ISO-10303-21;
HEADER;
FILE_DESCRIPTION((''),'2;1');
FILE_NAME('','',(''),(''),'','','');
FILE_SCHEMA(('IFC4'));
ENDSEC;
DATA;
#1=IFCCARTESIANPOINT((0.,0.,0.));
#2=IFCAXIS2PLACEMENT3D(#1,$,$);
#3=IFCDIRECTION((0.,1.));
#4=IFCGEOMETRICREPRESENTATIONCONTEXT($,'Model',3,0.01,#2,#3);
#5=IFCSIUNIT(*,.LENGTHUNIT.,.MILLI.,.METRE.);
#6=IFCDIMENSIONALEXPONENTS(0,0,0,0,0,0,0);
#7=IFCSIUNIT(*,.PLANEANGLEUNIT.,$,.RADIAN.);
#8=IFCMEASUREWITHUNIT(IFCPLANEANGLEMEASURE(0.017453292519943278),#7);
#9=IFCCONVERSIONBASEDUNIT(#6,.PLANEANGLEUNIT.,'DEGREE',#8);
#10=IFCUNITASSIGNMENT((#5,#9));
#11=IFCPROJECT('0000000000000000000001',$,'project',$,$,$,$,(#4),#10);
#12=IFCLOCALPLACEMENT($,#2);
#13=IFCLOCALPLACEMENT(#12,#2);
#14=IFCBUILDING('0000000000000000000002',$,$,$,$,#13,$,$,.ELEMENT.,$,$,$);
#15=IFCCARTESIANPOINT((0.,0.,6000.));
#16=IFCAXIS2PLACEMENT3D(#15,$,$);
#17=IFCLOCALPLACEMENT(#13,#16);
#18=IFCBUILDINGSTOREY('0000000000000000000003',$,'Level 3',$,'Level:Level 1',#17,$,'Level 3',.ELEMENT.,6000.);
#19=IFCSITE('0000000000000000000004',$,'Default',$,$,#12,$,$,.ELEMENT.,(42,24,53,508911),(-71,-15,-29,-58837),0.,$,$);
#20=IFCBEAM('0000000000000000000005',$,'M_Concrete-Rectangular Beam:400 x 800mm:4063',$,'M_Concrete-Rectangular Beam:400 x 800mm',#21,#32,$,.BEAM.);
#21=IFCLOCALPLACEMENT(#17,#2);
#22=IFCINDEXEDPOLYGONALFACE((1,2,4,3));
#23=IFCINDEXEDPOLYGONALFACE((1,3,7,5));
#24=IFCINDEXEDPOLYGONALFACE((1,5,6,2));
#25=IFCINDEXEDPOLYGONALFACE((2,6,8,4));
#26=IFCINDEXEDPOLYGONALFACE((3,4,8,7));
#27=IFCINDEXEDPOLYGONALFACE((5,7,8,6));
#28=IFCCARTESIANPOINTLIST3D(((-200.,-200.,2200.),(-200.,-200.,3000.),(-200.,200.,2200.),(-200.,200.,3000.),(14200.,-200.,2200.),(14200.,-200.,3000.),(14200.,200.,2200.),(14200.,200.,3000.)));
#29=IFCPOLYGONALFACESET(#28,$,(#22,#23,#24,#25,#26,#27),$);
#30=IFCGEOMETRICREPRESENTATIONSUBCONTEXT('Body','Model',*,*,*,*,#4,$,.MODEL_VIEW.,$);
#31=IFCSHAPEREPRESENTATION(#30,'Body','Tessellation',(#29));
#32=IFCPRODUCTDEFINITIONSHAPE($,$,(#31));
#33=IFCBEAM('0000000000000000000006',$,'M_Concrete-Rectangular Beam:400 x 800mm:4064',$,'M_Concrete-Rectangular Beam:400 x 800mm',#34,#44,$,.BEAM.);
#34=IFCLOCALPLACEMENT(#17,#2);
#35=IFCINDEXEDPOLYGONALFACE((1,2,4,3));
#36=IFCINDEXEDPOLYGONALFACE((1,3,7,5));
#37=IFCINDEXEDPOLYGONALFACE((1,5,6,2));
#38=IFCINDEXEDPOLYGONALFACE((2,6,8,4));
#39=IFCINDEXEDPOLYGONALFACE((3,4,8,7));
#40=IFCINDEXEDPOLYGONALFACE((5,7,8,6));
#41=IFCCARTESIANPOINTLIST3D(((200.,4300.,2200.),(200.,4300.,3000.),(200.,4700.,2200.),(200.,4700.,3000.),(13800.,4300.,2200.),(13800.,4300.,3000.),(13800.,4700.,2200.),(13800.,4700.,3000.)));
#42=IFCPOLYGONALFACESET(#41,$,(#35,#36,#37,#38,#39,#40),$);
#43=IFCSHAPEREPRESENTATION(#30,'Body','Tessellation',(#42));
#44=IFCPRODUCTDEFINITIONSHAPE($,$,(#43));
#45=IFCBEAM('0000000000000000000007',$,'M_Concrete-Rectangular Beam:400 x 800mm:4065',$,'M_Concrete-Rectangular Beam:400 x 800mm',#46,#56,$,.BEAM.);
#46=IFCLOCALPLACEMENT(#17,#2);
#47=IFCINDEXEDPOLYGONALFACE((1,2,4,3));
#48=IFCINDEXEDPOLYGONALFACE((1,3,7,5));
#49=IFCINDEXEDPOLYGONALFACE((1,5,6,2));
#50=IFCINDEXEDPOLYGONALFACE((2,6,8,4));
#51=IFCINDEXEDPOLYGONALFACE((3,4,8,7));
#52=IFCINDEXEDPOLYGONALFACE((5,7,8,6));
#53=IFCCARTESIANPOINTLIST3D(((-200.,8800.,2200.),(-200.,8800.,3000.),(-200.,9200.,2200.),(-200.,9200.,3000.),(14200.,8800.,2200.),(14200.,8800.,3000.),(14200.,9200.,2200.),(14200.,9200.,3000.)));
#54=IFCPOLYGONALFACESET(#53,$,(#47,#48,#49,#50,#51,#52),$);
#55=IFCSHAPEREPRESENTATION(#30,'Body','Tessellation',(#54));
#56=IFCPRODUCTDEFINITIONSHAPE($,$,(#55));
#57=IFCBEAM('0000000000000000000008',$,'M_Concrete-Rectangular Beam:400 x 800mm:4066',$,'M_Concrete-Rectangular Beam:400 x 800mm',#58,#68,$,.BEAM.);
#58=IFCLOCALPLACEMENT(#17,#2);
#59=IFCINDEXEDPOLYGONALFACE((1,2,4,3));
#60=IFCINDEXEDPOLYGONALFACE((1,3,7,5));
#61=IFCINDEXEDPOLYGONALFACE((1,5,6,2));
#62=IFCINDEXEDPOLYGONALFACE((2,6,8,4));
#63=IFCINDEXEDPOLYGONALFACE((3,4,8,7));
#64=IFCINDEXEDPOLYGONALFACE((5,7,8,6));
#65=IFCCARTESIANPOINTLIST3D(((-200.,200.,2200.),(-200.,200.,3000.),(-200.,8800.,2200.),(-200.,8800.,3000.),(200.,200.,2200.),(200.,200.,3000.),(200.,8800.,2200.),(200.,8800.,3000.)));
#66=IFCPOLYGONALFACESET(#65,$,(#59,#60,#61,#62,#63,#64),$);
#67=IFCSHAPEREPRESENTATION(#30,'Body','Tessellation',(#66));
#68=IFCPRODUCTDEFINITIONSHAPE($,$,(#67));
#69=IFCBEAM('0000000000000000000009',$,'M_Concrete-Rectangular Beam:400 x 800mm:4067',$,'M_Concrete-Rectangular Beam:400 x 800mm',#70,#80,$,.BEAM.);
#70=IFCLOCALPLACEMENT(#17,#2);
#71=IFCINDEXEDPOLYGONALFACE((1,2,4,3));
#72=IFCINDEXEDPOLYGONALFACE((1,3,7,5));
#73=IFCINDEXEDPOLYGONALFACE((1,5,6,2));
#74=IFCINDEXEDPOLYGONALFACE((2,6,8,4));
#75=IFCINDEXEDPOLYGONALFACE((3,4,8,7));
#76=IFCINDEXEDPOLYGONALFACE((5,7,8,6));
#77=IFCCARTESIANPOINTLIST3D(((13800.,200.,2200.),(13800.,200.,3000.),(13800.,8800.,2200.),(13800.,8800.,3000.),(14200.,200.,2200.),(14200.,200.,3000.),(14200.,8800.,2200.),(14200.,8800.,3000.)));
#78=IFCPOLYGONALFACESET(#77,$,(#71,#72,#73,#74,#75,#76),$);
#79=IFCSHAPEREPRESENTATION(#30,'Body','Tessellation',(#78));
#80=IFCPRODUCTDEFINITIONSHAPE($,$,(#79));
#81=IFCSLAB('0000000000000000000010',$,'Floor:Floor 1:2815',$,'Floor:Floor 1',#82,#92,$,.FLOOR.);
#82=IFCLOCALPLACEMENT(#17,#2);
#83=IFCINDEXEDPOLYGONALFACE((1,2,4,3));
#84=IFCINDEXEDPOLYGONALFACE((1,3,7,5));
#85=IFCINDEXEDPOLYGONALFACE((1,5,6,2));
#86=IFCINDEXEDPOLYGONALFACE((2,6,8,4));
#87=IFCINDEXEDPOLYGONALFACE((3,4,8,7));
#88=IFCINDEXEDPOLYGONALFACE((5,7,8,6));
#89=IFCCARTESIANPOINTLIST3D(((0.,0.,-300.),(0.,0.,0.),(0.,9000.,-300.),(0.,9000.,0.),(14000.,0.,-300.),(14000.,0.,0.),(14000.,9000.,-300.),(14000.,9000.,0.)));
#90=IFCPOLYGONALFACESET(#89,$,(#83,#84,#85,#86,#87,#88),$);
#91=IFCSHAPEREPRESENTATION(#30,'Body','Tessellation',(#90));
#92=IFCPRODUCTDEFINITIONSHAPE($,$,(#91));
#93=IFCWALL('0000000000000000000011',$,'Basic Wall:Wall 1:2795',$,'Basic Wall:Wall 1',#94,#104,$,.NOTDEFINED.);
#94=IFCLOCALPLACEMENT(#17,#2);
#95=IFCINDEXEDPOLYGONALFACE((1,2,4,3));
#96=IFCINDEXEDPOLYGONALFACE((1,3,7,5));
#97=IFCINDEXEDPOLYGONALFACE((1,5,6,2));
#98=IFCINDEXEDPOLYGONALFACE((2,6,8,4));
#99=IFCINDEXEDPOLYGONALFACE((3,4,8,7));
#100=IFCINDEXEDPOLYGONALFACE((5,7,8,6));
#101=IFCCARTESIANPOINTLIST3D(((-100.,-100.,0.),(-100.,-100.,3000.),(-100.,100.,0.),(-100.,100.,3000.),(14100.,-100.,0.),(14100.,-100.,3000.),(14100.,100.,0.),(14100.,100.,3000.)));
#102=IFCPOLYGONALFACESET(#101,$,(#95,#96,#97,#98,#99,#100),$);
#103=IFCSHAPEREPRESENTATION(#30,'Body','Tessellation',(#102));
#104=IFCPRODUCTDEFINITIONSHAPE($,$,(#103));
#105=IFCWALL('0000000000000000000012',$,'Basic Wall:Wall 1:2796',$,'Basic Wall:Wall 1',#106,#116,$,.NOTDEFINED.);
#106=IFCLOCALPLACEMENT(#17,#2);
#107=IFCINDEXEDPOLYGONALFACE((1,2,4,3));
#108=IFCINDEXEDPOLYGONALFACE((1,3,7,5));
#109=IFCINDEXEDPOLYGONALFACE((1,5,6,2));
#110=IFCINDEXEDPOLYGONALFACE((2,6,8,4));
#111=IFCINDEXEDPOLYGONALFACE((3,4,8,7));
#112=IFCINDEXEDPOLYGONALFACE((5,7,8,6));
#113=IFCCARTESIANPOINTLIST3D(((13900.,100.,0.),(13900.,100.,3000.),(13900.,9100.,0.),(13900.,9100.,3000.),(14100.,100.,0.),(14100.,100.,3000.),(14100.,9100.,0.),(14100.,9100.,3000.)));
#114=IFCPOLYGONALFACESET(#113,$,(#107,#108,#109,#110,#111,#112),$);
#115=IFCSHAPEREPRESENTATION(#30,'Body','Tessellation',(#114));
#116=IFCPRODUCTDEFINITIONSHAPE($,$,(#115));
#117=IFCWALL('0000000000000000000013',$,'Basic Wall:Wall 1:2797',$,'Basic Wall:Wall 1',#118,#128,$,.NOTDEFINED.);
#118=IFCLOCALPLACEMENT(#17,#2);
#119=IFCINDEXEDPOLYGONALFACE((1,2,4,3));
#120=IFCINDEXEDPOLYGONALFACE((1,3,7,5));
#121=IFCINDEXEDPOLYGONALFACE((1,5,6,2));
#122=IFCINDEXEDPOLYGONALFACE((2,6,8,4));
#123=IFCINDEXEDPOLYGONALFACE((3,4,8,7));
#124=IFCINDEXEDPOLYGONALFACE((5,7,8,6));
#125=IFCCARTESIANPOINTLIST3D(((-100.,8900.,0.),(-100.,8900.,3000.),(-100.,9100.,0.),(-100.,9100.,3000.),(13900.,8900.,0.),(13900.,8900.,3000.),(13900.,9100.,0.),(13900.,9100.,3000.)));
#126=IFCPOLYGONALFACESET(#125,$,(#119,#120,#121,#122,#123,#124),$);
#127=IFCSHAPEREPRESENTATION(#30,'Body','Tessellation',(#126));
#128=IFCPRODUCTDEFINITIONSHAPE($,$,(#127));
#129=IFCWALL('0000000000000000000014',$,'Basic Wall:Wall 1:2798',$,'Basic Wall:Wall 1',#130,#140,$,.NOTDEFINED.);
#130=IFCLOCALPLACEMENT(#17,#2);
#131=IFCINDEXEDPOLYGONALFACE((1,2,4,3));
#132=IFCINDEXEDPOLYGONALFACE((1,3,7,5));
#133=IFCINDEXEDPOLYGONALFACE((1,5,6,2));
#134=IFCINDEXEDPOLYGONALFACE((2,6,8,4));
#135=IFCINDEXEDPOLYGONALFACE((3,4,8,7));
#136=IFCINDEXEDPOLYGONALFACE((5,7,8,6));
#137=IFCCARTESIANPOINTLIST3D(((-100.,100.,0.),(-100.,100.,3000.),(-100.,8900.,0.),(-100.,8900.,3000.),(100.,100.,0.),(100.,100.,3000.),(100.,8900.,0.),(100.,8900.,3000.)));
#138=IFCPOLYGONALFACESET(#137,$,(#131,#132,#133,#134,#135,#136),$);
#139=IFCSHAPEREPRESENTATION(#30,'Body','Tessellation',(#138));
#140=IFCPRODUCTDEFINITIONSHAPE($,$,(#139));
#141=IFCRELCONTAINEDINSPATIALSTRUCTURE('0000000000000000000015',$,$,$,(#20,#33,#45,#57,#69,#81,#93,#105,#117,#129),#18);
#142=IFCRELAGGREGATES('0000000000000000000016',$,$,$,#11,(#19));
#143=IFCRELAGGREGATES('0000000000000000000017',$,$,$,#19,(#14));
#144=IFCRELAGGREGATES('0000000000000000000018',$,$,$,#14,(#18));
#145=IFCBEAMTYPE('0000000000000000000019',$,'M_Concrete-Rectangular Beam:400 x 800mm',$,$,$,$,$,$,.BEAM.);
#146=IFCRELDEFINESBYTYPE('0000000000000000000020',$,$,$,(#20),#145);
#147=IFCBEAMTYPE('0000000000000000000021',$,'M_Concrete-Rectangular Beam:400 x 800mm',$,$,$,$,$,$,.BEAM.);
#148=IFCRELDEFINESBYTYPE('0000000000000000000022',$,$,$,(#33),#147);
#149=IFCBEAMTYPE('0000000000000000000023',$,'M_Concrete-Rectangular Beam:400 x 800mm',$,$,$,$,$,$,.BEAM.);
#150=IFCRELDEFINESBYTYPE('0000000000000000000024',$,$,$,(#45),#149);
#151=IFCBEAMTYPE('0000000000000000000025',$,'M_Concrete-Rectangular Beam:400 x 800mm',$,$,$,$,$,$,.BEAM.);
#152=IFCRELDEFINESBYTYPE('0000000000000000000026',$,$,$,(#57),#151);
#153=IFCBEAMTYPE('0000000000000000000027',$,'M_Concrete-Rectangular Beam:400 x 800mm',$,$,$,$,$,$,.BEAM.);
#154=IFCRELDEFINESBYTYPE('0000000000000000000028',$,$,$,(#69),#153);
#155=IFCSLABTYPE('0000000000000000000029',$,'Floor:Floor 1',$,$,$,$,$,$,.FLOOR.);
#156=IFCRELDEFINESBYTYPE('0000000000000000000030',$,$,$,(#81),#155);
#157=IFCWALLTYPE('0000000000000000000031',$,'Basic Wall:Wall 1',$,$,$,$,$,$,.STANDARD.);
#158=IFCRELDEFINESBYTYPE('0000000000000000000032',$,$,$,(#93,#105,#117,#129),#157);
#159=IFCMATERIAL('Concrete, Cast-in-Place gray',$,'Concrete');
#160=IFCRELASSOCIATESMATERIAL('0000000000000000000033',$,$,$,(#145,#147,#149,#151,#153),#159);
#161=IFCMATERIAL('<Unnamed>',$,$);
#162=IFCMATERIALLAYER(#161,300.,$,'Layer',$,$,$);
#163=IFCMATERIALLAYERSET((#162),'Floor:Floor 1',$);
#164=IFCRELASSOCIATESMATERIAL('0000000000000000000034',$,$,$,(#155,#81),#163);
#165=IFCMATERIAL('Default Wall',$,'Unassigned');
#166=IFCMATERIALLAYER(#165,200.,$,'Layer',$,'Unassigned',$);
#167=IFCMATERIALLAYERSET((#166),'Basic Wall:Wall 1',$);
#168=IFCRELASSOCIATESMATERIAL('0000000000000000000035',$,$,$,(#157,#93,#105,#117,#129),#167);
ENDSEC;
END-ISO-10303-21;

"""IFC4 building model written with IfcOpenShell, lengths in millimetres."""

from ifc_helpers import new_model, entity, si_unit, converted_unit, direction, frame, frame_2d, origin, origin_2d_with_axis, place, context, subcontext, project, spatial, rectangle, extrude, source, transform, mapped, material, layer, layer_set, layer_usage, material_profile, profile_set, type_object, type_shapes, element, save


model = new_model("IFC4")

# Units and contexts
model_context = context("Model", 3, precision=0.01, world=origin(), true_north=direction((0.0, 1.0)))
body_context = subcontext(model_context, "Body", "Model", "MODEL_VIEW")
ifc_project = project(units=[si_unit("LENGTHUNIT", "METRE", prefix="MILLI"), converted_unit("PLANEANGLEUNIT", "DEGREE", entity("IfcPlaneAngleMeasure", 0.017453292519943278), si_unit("PLANEANGLEUNIT", "RADIAN"), dimensions=[0, 0, 0, 0, 0, 0, 0])], contexts=[model_context])

# Site, building, storey
site_placement = place(None, origin())
site = spatial("IfcSite", under=ifc_project, at=site_placement, Name="Default", CompositionType="ELEMENT", RefLatitude=(42, 24, 53, 508911), RefLongitude=(-71, -15, -29, -58837), RefElevation=0.0)
building_placement = place(site_placement, origin())
building = spatial("IfcBuilding", under=site, at=building_placement, CompositionType="ELEMENT")
storey_placement = place(building_placement, frame((0.0, 0.0, 6000.0)))
storey = spatial("IfcBuildingStorey", under=building, at=storey_placement, Name="Level 3", ObjectType="Level:Level 1", LongName="Level 3", CompositionType="ELEMENT", Elevation=6000.0)

# Beams
ifc_material_1 = material(Name="Concrete, Cast-in-Place gray", Category="Concrete")
ifc_material_profile = material_profile(ifc_material_1, rectangle(XDim=800.0, YDim=400.0, at=origin_2d_with_axis()), Name="400 x 800mm")
ifc_profile_set = profile_set([ifc_material_profile], Name="400 x 800mm")
beam_type_1 = type_object("IfcBeamType", Name="M_Concrete-Rectangular Beam:400 x 800mm", PredefinedType="BEAM", material=ifc_profile_set)
shared_shape_1 = source(origin(), body_context, "Body", "SweptSolid", [
    extrude(rectangle(XDim=800.0, YDim=400.0, at=origin_2d_with_axis()), frame((-200.0, 0.0, 8600.0), z_axis=(1.0, 0.0, 0.0), x_axis=(0.0, 0.0, -1.0)), (0.0, 0.0, 1.0), 14400.0),
])
type_shapes(beam_type_1, [shared_shape_1])
beam_1_placement = place(storey_placement, frame((0.0, 0.0, -6000.0)))
element("IfcBeam", 1, at=beam_1_placement, inside=storey, type_object=beam_type_1, Name="M_Concrete-Rectangular Beam:400 x 800mm:4063", ObjectType="M_Concrete-Rectangular Beam:400 x 800mm", PredefinedType="BEAM", context=body_context, shape_type="MappedRepresentation", body=[
    mapped(shared_shape_1, transform((0.0, 0.0, 0.0), scale=1.0)),
])
beam_type_2 = type_object("IfcBeamType", Name="M_Concrete-Rectangular Beam:400 x 800mm", PredefinedType="BEAM", material=ifc_profile_set)
shared_shape_2 = source(origin(), body_context, "Body", "SweptSolid", [
    extrude(rectangle(XDim=800.0, YDim=400.0, at=origin_2d_with_axis()), frame((200.0, 4500.0, 8600.0), z_axis=(1.0, 0.0, 0.0), x_axis=(0.0, 0.0, -1.0)), (0.0, 0.0, 1.0), 13600.0),
])
type_shapes(beam_type_2, [shared_shape_2])
beam_2_placement = place(storey_placement, frame((0.0, 0.0, -6000.0)))
element("IfcBeam", 2, at=beam_2_placement, inside=storey, type_object=beam_type_2, Name="M_Concrete-Rectangular Beam:400 x 800mm:4064", ObjectType="M_Concrete-Rectangular Beam:400 x 800mm", PredefinedType="BEAM", context=body_context, shape_type="MappedRepresentation", body=[
    mapped(shared_shape_2, transform((0.0, 0.0, 0.0), scale=1.0)),
])
beam_type_3 = type_object("IfcBeamType", Name="M_Concrete-Rectangular Beam:400 x 800mm", PredefinedType="BEAM", material=ifc_profile_set)
shared_shape_3 = source(origin(), body_context, "Body", "SweptSolid", [
    extrude(rectangle(XDim=800.0, YDim=400.0, at=frame_2d((0.0, 0.0), x_axis=(1.0, 0.0))), frame((-200.0, 9000.0, 8600.0), z_axis=(1.0, 0.0, 0.0), x_axis=(0.0, 0.0, -1.0)), (0.0, 0.0, 1.0), 14400.0),
])
type_shapes(beam_type_3, [shared_shape_3])
beam_3_placement = place(storey_placement, frame((0.0, 0.0, -6000.0)))
element("IfcBeam", 3, at=beam_3_placement, inside=storey, type_object=beam_type_3, Name="M_Concrete-Rectangular Beam:400 x 800mm:4065", ObjectType="M_Concrete-Rectangular Beam:400 x 800mm", PredefinedType="BEAM", context=body_context, shape_type="MappedRepresentation", body=[
    mapped(shared_shape_3, transform((0.0, 0.0, 0.0), scale=1.0)),
])
beam_type_4 = type_object("IfcBeamType", Name="M_Concrete-Rectangular Beam:400 x 800mm", PredefinedType="BEAM", material=ifc_profile_set)
shared_shape_4 = source(origin(), body_context, "Body", "SweptSolid", [
    extrude(rectangle(XDim=800.0, YDim=400.0, at=frame_2d((0.0, 0.0), x_axis=(0.0, 1.0))), frame((0.0, 200.0, 8600.0), z_axis=(0.0, 1.0, 0.0), x_axis=(-1.0, 0.0, 0.0)), (0.0, 0.0, 1.0), 8600.0),
])
type_shapes(beam_type_4, [shared_shape_4])
beam_4_placement = place(storey_placement, frame((0.0, 0.0, -6000.0)))
element("IfcBeam", 4, at=beam_4_placement, inside=storey, type_object=beam_type_4, Name="M_Concrete-Rectangular Beam:400 x 800mm:4066", ObjectType="M_Concrete-Rectangular Beam:400 x 800mm", PredefinedType="BEAM", context=body_context, shape_type="MappedRepresentation", body=[
    mapped(shared_shape_4, transform((0.0, 0.0, 0.0), scale=1.0)),
])
beam_type_5 = type_object("IfcBeamType", Name="M_Concrete-Rectangular Beam:400 x 800mm", PredefinedType="BEAM", material=ifc_profile_set)
shared_shape_5 = source(origin(), body_context, "Body", "SweptSolid", [
    extrude(rectangle(XDim=800.0, YDim=400.0, at=frame_2d((0.0, 0.0), x_axis=(0.0, 1.0))), frame((14000.0, 200.0, 8600.0), z_axis=(0.0, 1.0, 0.0), x_axis=(-1.0, 0.0, 0.0)), (0.0, 0.0, 1.0), 8600.0),
])
type_shapes(beam_type_5, [shared_shape_5])
beam_5_placement = place(storey_placement, frame((0.0, 0.0, -6000.0)))
element("IfcBeam", 5, at=beam_5_placement, inside=storey, type_object=beam_type_5, Name="M_Concrete-Rectangular Beam:400 x 800mm:4067", ObjectType="M_Concrete-Rectangular Beam:400 x 800mm", PredefinedType="BEAM", context=body_context, shape_type="MappedRepresentation", body=[
    mapped(shared_shape_5, transform((0.0, 0.0, 0.0), scale=1.0)),
])

# Slab
ifc_material_2 = material(Name="<Unnamed>")
ifc_layer_1 = layer(ifc_material_2, 300.0, Name="Layer")
ifc_layer_set_1 = layer_set([ifc_layer_1], Name="Floor:Floor 1")
ifc_layer_usage_1 = layer_usage(ifc_layer_set_1, "AXIS3", "POSITIVE", 0.0)
slab_type = type_object("IfcSlabType", Name="Floor:Floor 1", PredefinedType="FLOOR", material=ifc_layer_set_1)
slab_placement = place(storey_placement, origin())
element("IfcSlab", 6, at=slab_placement, inside=storey, type_object=slab_type, material=ifc_layer_usage_1, Name="Floor:Floor 1:2815", ObjectType="Floor:Floor 1", PredefinedType="FLOOR", context=body_context, shape_type="SweptSolid", body=[
    extrude(rectangle(XDim=9000.0, YDim=14000.0, at=origin_2d_with_axis()), frame((7000.0, 4500.0, 0.0), z_axis=(0.0, 0.0, -1.0), x_axis=(0.0, 1.0, 0.0)), (0.0, 0.0, 1.0), 300.0),
])

# Walls
ifc_material_3 = material(Name="Default Wall", Category="Unassigned")
ifc_layer_2 = layer(ifc_material_3, 200.0, Name="Layer", Category="Unassigned")
ifc_layer_set_2 = layer_set([ifc_layer_2], Name="Basic Wall:Wall 1")
ifc_layer_usage_2 = layer_usage(ifc_layer_set_2, "AXIS2", "NEGATIVE", 100.0)
wall_type = type_object("IfcWallType", Name="Basic Wall:Wall 1", PredefinedType="STANDARD", material=ifc_layer_set_2)
wall_1_placement = place(storey_placement, frame((-100.0, 0.0, 0.0)))
element("IfcWall", 7, at=wall_1_placement, inside=storey, type_object=wall_type, material=ifc_layer_usage_2, Name="Basic Wall:Wall 1:2795", ObjectType="Basic Wall:Wall 1", PredefinedType="NOTDEFINED", context=body_context, shape_type="SweptSolid", body=[
    extrude(rectangle(XDim=14200.0, YDim=200.0, at=frame_2d((7100.0, 0.0), x_axis=(-1.0, 0.0))), origin(), (0.0, 0.0, 1.0), 3000.0),
])
ifc_layer_usage_3 = layer_usage(ifc_layer_set_2, "AXIS2", "NEGATIVE", 100.0)
wall_2_placement = place(storey_placement, frame((14000.0, 100.0, 0.0), z_axis=(0.0, 0.0, 1.0), x_axis=(0.0, 1.0, 0.0)))
element("IfcWall", 8, at=wall_2_placement, inside=storey, type_object=wall_type, material=ifc_layer_usage_3, Name="Basic Wall:Wall 1:2796", ObjectType="Basic Wall:Wall 1", PredefinedType="NOTDEFINED", context=body_context, shape_type="SweptSolid", body=[
    extrude(rectangle(XDim=9000.0, YDim=200.0, at=frame_2d((4500.0, 0.0), x_axis=(-1.0, 0.0))), origin(), (0.0, 0.0, 1.0), 3000.0),
])
ifc_layer_usage_4 = layer_usage(ifc_layer_set_2, "AXIS2", "NEGATIVE", 100.0)
wall_3_placement = place(storey_placement, frame((13900.0, 9000.0, 0.0), z_axis=(0.0, 0.0, 1.0), x_axis=(-1.0, 0.0, 0.0)))
element("IfcWall", 9, at=wall_3_placement, inside=storey, type_object=wall_type, material=ifc_layer_usage_4, Name="Basic Wall:Wall 1:2797", ObjectType="Basic Wall:Wall 1", PredefinedType="NOTDEFINED", context=body_context, shape_type="SweptSolid", body=[
    extrude(rectangle(XDim=14000.0, YDim=200.0, at=frame_2d((7000.0, 0.0), x_axis=(-1.0, 0.0))), origin(), (0.0, 0.0, 1.0), 3000.0),
])
ifc_layer_usage_5 = layer_usage(ifc_layer_set_2, "AXIS2", "NEGATIVE", 100.0)
wall_4_placement = place(storey_placement, frame((0.0, 8900.0, 0.0), z_axis=(0.0, 0.0, 1.0), x_axis=(0.0, -1.0, 0.0)))
element("IfcWall", 10, at=wall_4_placement, inside=storey, type_object=wall_type, material=ifc_layer_usage_5, Name="Basic Wall:Wall 1:2798", ObjectType="Basic Wall:Wall 1", PredefinedType="NOTDEFINED", context=body_context, shape_type="SweptSolid", body=[
    extrude(rectangle(XDim=8800.0, YDim=200.0, at=frame_2d((4400.0, 0.0), x_axis=(-1.0, 0.0))), origin(), (0.0, 0.0, 1.0), 3000.0),
])

save(model, "model.ifc")
